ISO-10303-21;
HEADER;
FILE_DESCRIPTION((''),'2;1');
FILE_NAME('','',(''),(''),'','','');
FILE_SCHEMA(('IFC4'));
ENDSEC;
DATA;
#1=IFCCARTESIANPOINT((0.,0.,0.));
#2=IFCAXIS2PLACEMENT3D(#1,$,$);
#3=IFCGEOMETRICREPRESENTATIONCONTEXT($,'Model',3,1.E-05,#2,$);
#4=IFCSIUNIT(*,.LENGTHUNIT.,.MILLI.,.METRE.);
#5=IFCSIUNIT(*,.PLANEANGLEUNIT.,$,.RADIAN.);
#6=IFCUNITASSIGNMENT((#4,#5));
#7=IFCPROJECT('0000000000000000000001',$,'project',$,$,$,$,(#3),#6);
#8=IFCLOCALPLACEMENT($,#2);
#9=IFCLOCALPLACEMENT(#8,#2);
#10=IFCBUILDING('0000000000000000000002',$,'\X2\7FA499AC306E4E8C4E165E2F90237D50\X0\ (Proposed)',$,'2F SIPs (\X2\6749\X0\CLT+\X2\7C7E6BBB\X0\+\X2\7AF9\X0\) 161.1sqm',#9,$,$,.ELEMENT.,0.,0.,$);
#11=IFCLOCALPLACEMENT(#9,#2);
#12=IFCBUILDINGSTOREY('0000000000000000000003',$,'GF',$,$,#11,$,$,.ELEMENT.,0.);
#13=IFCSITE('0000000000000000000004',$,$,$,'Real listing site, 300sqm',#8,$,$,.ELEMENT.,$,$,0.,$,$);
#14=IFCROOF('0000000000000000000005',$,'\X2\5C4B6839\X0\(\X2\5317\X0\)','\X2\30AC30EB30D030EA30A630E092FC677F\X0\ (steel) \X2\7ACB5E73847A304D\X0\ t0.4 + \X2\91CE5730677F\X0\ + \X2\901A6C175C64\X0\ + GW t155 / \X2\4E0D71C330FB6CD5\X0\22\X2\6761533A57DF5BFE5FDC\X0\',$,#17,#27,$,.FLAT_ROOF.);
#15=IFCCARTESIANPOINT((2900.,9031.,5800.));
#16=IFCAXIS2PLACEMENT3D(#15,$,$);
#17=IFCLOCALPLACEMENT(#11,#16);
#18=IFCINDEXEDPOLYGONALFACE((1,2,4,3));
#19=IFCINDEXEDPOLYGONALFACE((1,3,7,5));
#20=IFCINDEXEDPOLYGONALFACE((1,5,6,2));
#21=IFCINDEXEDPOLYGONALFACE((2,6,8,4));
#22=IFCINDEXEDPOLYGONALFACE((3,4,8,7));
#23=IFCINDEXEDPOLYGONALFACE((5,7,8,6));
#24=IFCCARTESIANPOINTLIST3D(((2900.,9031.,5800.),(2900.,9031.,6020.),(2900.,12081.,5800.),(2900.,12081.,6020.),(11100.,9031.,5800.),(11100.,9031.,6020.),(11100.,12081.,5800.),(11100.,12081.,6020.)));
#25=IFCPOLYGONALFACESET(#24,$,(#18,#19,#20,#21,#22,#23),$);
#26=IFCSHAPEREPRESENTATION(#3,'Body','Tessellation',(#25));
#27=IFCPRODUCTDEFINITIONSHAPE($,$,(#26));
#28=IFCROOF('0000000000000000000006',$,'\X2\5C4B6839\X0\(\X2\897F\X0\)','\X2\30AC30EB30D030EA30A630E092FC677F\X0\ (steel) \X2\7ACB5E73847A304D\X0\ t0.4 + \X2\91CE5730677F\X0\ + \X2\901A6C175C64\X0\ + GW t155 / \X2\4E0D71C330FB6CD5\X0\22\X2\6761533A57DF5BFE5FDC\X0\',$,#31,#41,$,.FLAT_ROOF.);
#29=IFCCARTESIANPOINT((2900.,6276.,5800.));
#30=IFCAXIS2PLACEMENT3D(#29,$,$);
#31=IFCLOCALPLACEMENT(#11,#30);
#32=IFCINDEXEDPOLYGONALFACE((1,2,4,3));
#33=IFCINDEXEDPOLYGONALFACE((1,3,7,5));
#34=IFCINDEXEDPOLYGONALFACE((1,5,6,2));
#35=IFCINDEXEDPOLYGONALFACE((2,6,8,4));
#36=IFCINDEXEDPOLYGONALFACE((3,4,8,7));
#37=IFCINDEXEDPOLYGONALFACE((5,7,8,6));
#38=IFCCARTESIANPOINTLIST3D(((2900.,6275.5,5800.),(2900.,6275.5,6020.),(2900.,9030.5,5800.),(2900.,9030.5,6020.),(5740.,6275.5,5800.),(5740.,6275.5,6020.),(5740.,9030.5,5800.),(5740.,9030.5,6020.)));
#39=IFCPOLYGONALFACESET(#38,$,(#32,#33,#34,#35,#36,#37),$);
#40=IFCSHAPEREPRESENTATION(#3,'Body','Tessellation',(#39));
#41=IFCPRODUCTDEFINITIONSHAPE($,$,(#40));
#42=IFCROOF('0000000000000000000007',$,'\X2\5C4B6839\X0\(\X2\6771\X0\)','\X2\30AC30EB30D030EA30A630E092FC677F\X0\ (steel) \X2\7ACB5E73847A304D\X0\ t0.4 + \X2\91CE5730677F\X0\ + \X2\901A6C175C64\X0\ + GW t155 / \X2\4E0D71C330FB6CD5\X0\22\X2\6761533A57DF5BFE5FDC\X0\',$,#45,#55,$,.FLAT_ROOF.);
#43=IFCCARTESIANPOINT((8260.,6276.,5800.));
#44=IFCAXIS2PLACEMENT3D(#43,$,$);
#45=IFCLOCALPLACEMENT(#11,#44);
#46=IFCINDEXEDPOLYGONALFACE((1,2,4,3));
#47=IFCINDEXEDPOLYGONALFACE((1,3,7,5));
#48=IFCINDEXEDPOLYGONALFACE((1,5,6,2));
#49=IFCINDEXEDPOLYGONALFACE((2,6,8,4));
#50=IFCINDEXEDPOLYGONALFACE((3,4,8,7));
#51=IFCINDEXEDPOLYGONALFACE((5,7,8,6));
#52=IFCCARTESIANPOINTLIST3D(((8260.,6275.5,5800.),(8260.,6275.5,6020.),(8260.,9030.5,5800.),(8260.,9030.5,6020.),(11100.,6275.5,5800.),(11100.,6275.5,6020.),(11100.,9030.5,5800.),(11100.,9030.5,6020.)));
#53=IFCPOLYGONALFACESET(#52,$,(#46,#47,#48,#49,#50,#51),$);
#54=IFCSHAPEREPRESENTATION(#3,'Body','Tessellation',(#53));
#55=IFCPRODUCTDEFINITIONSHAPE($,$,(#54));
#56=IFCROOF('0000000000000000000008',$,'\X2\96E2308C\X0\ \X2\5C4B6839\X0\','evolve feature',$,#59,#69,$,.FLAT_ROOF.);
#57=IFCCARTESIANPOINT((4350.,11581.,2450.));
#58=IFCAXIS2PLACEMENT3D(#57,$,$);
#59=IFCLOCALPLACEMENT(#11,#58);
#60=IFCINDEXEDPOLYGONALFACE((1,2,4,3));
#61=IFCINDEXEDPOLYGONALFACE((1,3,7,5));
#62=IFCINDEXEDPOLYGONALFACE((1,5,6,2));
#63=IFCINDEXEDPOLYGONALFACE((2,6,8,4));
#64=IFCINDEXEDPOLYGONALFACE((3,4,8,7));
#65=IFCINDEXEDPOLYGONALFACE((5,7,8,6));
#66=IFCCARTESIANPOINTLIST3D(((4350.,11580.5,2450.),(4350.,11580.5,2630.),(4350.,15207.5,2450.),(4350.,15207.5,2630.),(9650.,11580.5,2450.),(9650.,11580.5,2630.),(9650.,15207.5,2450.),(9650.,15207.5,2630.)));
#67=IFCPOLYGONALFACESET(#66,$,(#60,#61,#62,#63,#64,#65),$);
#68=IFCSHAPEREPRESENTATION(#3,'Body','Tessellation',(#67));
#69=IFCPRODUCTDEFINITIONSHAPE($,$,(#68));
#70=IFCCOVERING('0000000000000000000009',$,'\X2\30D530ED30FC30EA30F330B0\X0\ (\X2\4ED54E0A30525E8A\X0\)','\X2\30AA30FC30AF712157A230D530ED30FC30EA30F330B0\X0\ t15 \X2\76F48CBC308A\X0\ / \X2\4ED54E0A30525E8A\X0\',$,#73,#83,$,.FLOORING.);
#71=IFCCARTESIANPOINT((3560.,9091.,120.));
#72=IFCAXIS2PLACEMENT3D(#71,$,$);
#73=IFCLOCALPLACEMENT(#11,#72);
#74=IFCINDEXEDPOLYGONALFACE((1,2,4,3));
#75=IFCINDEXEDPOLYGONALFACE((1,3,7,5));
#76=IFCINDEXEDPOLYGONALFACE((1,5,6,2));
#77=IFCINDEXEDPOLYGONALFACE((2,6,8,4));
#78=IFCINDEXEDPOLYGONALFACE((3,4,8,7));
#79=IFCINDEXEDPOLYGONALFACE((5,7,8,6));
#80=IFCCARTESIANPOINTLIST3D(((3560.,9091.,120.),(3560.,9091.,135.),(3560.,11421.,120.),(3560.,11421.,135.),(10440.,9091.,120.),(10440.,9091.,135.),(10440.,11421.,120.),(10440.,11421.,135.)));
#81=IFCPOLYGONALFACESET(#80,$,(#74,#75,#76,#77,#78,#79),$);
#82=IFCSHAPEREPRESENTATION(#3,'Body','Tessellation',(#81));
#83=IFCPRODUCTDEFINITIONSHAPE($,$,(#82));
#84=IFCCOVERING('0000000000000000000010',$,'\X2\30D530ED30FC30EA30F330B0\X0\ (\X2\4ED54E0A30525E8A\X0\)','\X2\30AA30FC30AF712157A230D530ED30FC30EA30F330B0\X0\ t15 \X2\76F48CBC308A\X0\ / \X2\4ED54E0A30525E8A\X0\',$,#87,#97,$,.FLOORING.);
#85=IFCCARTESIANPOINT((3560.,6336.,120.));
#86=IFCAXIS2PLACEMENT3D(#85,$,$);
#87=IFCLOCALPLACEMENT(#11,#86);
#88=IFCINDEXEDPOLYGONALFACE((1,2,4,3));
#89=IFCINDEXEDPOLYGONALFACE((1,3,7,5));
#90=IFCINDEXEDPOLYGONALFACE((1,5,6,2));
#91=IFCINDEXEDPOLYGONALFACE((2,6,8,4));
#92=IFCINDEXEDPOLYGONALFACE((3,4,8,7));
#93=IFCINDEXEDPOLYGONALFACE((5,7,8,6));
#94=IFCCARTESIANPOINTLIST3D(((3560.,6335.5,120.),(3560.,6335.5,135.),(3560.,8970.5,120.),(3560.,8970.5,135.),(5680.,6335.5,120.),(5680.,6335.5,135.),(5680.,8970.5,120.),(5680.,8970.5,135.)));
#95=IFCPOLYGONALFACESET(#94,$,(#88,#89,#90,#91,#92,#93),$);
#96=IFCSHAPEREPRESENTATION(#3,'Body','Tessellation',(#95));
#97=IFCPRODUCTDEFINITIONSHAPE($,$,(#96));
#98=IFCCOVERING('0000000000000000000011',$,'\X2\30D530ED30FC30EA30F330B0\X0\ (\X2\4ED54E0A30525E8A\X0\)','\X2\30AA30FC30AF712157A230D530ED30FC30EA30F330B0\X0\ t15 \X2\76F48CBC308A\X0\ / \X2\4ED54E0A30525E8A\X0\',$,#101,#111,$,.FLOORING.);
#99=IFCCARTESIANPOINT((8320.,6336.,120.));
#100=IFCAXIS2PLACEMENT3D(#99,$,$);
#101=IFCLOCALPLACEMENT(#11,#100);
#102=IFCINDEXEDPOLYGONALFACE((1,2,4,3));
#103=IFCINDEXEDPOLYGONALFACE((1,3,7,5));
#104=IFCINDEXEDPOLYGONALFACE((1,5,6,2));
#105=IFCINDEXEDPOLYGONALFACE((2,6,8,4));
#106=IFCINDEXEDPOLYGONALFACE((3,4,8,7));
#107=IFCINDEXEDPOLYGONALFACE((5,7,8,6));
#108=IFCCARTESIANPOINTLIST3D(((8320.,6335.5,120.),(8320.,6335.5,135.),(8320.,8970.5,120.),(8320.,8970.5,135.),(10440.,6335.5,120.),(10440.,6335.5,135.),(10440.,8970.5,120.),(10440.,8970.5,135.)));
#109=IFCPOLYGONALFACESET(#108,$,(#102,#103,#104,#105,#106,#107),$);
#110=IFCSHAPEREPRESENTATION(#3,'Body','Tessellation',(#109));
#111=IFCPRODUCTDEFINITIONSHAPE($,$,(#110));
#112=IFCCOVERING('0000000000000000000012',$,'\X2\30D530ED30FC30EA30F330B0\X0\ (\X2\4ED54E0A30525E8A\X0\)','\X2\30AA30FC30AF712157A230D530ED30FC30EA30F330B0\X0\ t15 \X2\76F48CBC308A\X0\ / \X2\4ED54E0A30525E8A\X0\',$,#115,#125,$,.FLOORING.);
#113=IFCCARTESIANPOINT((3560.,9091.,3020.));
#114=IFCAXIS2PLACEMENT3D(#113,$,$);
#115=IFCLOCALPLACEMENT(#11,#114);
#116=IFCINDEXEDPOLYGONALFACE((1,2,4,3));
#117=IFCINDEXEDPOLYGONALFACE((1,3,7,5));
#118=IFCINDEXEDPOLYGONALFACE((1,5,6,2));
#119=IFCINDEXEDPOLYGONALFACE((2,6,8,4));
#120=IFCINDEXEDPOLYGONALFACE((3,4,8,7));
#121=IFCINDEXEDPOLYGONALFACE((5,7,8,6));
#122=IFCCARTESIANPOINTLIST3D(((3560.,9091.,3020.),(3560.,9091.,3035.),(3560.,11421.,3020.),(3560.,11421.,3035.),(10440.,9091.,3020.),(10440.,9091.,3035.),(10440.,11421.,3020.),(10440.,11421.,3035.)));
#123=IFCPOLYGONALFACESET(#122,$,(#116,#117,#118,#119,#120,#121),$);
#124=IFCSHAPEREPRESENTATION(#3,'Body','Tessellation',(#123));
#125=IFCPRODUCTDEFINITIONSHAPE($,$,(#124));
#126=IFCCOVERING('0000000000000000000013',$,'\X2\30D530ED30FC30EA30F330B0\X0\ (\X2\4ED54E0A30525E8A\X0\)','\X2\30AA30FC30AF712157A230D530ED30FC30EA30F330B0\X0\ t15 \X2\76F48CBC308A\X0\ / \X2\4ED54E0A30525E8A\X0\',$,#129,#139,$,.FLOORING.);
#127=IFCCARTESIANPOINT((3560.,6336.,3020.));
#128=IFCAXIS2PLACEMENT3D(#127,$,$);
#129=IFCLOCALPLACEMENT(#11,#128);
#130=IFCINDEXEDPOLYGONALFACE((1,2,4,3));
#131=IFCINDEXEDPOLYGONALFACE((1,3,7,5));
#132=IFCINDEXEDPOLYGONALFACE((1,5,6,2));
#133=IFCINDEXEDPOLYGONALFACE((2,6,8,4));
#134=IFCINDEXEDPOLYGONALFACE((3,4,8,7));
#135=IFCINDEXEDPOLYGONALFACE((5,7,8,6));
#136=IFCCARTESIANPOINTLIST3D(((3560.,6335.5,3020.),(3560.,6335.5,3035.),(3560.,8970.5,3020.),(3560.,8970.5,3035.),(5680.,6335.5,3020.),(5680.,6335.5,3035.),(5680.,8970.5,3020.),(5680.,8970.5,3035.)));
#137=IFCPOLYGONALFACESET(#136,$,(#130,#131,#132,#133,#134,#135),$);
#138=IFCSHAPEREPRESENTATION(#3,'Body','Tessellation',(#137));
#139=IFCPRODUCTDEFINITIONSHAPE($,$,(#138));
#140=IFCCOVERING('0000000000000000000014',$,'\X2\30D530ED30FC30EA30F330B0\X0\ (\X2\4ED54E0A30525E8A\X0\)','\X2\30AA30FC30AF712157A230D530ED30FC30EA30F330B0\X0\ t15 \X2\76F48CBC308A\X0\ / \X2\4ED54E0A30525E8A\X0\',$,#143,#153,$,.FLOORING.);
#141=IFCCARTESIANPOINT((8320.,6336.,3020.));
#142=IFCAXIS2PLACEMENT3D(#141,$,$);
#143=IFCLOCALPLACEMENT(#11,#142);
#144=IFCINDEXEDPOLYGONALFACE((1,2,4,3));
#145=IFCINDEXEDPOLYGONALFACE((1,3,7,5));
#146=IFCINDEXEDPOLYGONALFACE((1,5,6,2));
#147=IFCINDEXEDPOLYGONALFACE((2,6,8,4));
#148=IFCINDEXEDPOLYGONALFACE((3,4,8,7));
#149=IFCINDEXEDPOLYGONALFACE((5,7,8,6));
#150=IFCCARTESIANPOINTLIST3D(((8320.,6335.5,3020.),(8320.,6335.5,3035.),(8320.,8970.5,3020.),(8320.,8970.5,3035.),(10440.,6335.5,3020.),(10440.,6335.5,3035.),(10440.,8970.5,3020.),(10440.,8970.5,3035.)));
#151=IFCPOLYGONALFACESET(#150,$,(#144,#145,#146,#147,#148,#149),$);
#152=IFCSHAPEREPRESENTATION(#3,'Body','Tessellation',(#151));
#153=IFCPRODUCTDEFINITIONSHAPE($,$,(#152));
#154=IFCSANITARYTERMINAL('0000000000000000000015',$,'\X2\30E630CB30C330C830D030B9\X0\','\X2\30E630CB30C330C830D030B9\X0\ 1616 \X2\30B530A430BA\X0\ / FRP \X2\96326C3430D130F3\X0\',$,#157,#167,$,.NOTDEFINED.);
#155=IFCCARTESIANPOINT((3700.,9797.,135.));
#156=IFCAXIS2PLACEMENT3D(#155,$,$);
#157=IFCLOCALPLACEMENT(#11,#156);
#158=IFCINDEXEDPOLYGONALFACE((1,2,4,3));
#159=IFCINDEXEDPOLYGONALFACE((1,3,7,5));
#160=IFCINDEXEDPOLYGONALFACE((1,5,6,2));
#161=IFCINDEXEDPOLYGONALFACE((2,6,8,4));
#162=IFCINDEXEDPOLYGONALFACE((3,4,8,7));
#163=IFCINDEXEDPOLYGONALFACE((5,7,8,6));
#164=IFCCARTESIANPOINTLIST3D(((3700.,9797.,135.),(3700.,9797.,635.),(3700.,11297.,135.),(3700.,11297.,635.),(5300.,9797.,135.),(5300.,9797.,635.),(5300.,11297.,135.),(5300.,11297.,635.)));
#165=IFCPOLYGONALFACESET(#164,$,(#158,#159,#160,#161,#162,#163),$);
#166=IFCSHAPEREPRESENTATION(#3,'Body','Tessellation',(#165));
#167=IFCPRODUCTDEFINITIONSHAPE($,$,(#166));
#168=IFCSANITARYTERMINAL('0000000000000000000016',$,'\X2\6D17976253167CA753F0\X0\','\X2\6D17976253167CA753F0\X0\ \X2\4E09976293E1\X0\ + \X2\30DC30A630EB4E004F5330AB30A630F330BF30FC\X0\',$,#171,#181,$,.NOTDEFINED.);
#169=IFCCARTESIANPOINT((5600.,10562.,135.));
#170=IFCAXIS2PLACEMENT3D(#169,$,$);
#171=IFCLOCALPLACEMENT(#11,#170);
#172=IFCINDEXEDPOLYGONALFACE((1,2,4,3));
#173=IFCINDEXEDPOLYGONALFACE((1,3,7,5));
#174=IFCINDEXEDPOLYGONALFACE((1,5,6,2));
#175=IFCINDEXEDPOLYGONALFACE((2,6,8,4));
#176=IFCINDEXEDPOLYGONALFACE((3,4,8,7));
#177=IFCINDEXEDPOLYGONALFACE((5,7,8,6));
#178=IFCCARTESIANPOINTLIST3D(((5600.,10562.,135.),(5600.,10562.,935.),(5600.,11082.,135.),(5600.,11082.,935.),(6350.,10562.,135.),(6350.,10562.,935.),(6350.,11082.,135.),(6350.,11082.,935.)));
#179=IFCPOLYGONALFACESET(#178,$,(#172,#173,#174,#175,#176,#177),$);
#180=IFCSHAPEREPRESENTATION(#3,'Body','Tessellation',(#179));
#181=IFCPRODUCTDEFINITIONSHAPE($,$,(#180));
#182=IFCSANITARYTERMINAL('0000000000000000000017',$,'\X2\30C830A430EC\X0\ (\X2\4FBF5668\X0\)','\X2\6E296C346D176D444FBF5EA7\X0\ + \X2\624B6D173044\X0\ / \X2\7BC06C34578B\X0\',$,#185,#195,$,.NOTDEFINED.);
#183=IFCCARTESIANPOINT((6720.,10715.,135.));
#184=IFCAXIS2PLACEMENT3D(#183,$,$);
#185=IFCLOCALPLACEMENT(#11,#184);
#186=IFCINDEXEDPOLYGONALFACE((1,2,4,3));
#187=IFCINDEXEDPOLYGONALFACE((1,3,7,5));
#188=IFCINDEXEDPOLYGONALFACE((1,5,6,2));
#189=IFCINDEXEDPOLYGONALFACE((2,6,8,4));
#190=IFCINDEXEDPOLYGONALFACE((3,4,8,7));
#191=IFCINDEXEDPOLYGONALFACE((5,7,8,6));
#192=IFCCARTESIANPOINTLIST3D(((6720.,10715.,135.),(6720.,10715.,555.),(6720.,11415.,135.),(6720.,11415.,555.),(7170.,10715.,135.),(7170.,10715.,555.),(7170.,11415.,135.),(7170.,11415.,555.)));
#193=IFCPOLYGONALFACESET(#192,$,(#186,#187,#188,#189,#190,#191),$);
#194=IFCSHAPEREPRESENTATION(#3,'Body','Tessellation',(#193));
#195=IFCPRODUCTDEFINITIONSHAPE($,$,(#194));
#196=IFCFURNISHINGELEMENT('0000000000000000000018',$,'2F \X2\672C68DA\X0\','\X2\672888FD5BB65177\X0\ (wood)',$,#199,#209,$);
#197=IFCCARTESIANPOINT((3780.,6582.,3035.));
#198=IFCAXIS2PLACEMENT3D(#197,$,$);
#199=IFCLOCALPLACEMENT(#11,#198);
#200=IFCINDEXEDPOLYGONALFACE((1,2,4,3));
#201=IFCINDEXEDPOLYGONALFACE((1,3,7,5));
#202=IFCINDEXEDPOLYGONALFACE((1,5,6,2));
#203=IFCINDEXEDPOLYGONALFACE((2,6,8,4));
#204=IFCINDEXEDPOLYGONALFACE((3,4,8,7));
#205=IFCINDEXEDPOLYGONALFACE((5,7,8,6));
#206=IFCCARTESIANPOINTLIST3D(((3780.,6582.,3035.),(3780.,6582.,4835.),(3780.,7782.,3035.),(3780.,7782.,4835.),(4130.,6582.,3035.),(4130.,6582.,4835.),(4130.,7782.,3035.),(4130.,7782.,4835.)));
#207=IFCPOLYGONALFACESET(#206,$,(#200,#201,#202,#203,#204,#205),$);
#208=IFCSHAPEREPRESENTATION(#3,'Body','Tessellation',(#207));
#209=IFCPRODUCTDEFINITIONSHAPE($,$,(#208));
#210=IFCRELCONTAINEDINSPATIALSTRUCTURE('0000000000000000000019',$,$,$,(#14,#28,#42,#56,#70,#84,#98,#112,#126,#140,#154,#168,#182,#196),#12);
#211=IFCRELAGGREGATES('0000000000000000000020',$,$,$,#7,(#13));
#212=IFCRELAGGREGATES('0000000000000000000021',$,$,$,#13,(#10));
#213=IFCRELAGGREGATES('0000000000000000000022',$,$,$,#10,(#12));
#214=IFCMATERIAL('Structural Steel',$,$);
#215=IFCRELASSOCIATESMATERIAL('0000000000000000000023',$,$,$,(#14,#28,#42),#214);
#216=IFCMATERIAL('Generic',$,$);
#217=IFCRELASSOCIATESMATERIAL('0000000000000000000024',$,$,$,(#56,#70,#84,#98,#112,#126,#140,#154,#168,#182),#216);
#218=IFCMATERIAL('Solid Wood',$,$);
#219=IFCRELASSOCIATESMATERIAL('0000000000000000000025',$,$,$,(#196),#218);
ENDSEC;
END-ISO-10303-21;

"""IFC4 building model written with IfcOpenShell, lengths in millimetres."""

from ifc_helpers import new_model, si_unit, frame, frame_2d, origin, place, context, project, spatial, rectangle, extrude, material, element, save


model = new_model("IFC4")

# Units and contexts
model_context = context("Model", 3, precision=1e-05, world=origin())
ifc_project = project(units=[si_unit("LENGTHUNIT", "METRE", prefix="MILLI"), si_unit("PLANEANGLEUNIT", "RADIAN")], contexts=[model_context])

# Site, building, storey
site_placement = place(None, origin())
site = spatial("IfcSite", under=ifc_project, at=site_placement, ObjectType="Real listing site, 300sqm", CompositionType="ELEMENT", RefElevation=0.0)
building_placement = place(site_placement, origin())
building = spatial("IfcBuilding", under=site, at=building_placement, Name="群馬の二世帯連結 (Proposed)", ObjectType="2F SIPs (杉CLT+籾殻+竹) 161.1sqm", CompositionType="ELEMENT", ElevationOfRefHeight=0.0, ElevationOfTerrain=0.0)
storey_placement = place(building_placement, origin())
storey = spatial("IfcBuildingStorey", under=building, at=storey_placement, Name="GF", CompositionType="ELEMENT", Elevation=0.0)

# Shared definitions
ifc_material_1 = material(Name="Solid Wood")
ifc_material_2 = material(Name="Generic")

# Roofs
ifc_material_3 = material(Name="Structural Steel")
for number, where, name in (
    (1, (2900.0, 9031.0, 5800.0), "屋根(北)"),
):
    element("IfcRoof", number, at=place(storey_placement, frame(where)), inside=storey, material=ifc_material_3, Name=name, Description="ガルバリウム鋼板 (steel) 立平葺き t0.4 + 野地板 + 通気層 + GW t155 / 不燃・法22条区域対応", PredefinedType="FLAT_ROOF", context=model_context, shape_type="SweptSolid", body=[
        extrude(rectangle(XDim=8200.0, YDim=3050.0, at=frame_2d((4100.0, 1525.0))), frame((2900.0, 9031.0, 5800.0)), (0.0, 0.0, 1.0), 220.0),
    ])
roof_1_placement = place(storey_placement, frame((2900.0, 6276.0, 5800.0)))
element("IfcRoof", 2, at=roof_1_placement, inside=storey, material=ifc_material_3, Name="屋根(西)", Description="ガルバリウム鋼板 (steel) 立平葺き t0.4 + 野地板 + 通気層 + GW t155 / 不燃・法22条区域対応", PredefinedType="FLAT_ROOF", context=model_context, shape_type="SweptSolid", body=[
    extrude(rectangle(XDim=2840.0, YDim=2755.0, at=frame_2d((1420.0, 1377.0))), frame((2900.0, 6276.0, 5800.0)), (0.0, 0.0, 1.0), 220.0),
])
roof_2_placement = place(storey_placement, frame((8260.0, 6276.0, 5800.0)))
element("IfcRoof", 3, at=roof_2_placement, inside=storey, material=ifc_material_3, Name="屋根(東)", Description="ガルバリウム鋼板 (steel) 立平葺き t0.4 + 野地板 + 通気層 + GW t155 / 不燃・法22条区域対応", PredefinedType="FLAT_ROOF", context=model_context, shape_type="SweptSolid", body=[
    extrude(rectangle(XDim=2840.0, YDim=2755.0, at=frame_2d((1420.0, 1377.0))), frame((8260.0, 6276.0, 5800.0)), (0.0, 0.0, 1.0), 220.0),
])
roof_3_placement = place(storey_placement, frame((4350.0, 11581.0, 2450.0)))
element("IfcRoof", 4, at=roof_3_placement, inside=storey, material=ifc_material_2, Name="離れ 屋根", Description="evolve feature", PredefinedType="FLAT_ROOF", context=model_context, shape_type="SweptSolid", body=[
    extrude(rectangle(XDim=5300.0, YDim=3627.0, at=frame_2d((2650.0, 1813.0))), frame((4350.0, 11581.0, 2450.0)), (0.0, 0.0, 1.0), 180.0),
])

# Coverings
covering_1_placement = place(storey_placement, frame((3560.0, 9091.0, 120.0)))
element("IfcCovering", 5, at=covering_1_placement, inside=storey, material=ifc_material_2, Name="フローリング (仕上げ床)", Description="オーク無垢フローリング t15 直貼り / 仕上げ床", PredefinedType="FLOORING", context=model_context, shape_type="SweptSolid", body=[
    extrude(rectangle(XDim=6880.0, YDim=2330.0, at=frame_2d((3440.0, 1165.0))), frame((3560.0, 9091.0, 120.0)), (0.0, 0.0, 1.0), 15.0),
])
covering_2_placement = place(storey_placement, frame((3560.0, 6336.0, 120.0)))
element("IfcCovering", 6, at=covering_2_placement, inside=storey, material=ifc_material_2, Name="フローリング (仕上げ床)", Description="オーク無垢フローリング t15 直貼り / 仕上げ床", PredefinedType="FLOORING", context=model_context, shape_type="SweptSolid", body=[
    extrude(rectangle(XDim=2120.0, YDim=2635.0, at=frame_2d((1060.0, 1317.0))), frame((3560.0, 6336.0, 120.0)), (0.0, 0.0, 1.0), 15.0),
])
covering_3_placement = place(storey_placement, frame((8320.0, 6336.0, 120.0)))
element("IfcCovering", 7, at=covering_3_placement, inside=storey, material=ifc_material_2, Name="フローリング (仕上げ床)", Description="オーク無垢フローリング t15 直貼り / 仕上げ床", PredefinedType="FLOORING", context=model_context, shape_type="SweptSolid", body=[
    extrude(rectangle(XDim=2120.0, YDim=2635.0, at=frame_2d((1060.0, 1317.0))), frame((8320.0, 6336.0, 120.0)), (0.0, 0.0, 1.0), 15.0),
])
covering_4_placement = place(storey_placement, frame((3560.0, 9091.0, 3020.0)))
element("IfcCovering", 8, at=covering_4_placement, inside=storey, material=ifc_material_2, Name="フローリング (仕上げ床)", Description="オーク無垢フローリング t15 直貼り / 仕上げ床", PredefinedType="FLOORING", context=model_context, shape_type="SweptSolid", body=[
    extrude(rectangle(XDim=6880.0, YDim=2330.0, at=frame_2d((3440.0, 1165.0))), frame((3560.0, 9091.0, 3020.0)), (0.0, 0.0, 1.0), 15.0),
])
covering_5_placement = place(storey_placement, frame((3560.0, 6336.0, 3020.0)))
element("IfcCovering", 9, at=covering_5_placement, inside=storey, material=ifc_material_2, Name="フローリング (仕上げ床)", Description="オーク無垢フローリング t15 直貼り / 仕上げ床", PredefinedType="FLOORING", context=model_context, shape_type="SweptSolid", body=[
    extrude(rectangle(XDim=2120.0, YDim=2635.0, at=frame_2d((1060.0, 1317.0))), frame((3560.0, 6336.0, 3020.0)), (0.0, 0.0, 1.0), 15.0),
])
covering_6_placement = place(storey_placement, frame((8320.0, 6336.0, 3020.0)))
element("IfcCovering", 10, at=covering_6_placement, inside=storey, material=ifc_material_2, Name="フローリング (仕上げ床)", Description="オーク無垢フローリング t15 直貼り / 仕上げ床", PredefinedType="FLOORING", context=model_context, shape_type="SweptSolid", body=[
    extrude(rectangle(XDim=2120.0, YDim=2635.0, at=frame_2d((1060.0, 1317.0))), frame((8320.0, 6336.0, 3020.0)), (0.0, 0.0, 1.0), 15.0),
])

# Sanitary terminals
sanitary_terminal_1_placement = place(storey_placement, frame((3700.0, 9797.0, 135.0)))
element("IfcSanitaryTerminal", 11, at=sanitary_terminal_1_placement, inside=storey, material=ifc_material_2, Name="ユニットバス", Description="ユニットバス 1616 サイズ / FRP 防水パン", PredefinedType="NOTDEFINED", context=model_context, shape_type="SweptSolid", body=[
    extrude(rectangle(XDim=1600.0, YDim=1500.0, at=frame_2d((800.0, 750.0))), frame((3700.0, 9797.0, 135.0)), (0.0, 0.0, 1.0), 500.0),
])
sanitary_terminal_2_placement = place(storey_placement, frame((5600.0, 10562.0, 135.0)))
element("IfcSanitaryTerminal", 12, at=sanitary_terminal_2_placement, inside=storey, material=ifc_material_2, Name="洗面化粧台", Description="洗面化粧台 三面鏡 + ボウル一体カウンター", PredefinedType="NOTDEFINED", context=model_context, shape_type="SweptSolid", body=[
    extrude(rectangle(XDim=750.0, YDim=520.0, at=frame_2d((375.0, 260.0))), frame((5600.0, 10562.0, 135.0)), (0.0, 0.0, 1.0), 800.0),
])
sanitary_terminal_3_placement = place(storey_placement, frame((6720.0, 10715.0, 135.0)))
element("IfcSanitaryTerminal", 13, at=sanitary_terminal_3_placement, inside=storey, material=ifc_material_2, Name="トイレ (便器)", Description="温水洗浄便座 + 手洗い / 節水型", PredefinedType="NOTDEFINED", context=model_context, shape_type="SweptSolid", body=[
    extrude(rectangle(XDim=450.0, YDim=700.0, at=frame_2d((225.0, 350.0))), frame((6720.0, 10715.0, 135.0)), (0.0, 0.0, 1.0), 420.0),
])

# Furnishing element
furnishing_placement = place(storey_placement, frame((3780.0, 6582.0, 3035.0)))
element("IfcFurnishingElement", 14, at=furnishing_placement, inside=storey, material=ifc_material_1, Name="2F 本棚", Description="木製家具 (wood)", context=model_context, shape_type="SweptSolid", body=[
    extrude(rectangle(XDim=350.0, YDim=1200.0, at=frame_2d((175.0, 600.0))), frame((3780.0, 6582.0, 3035.0)), (0.0, 0.0, 1.0), 1800.0),
])

save(model, "model.ifc")
